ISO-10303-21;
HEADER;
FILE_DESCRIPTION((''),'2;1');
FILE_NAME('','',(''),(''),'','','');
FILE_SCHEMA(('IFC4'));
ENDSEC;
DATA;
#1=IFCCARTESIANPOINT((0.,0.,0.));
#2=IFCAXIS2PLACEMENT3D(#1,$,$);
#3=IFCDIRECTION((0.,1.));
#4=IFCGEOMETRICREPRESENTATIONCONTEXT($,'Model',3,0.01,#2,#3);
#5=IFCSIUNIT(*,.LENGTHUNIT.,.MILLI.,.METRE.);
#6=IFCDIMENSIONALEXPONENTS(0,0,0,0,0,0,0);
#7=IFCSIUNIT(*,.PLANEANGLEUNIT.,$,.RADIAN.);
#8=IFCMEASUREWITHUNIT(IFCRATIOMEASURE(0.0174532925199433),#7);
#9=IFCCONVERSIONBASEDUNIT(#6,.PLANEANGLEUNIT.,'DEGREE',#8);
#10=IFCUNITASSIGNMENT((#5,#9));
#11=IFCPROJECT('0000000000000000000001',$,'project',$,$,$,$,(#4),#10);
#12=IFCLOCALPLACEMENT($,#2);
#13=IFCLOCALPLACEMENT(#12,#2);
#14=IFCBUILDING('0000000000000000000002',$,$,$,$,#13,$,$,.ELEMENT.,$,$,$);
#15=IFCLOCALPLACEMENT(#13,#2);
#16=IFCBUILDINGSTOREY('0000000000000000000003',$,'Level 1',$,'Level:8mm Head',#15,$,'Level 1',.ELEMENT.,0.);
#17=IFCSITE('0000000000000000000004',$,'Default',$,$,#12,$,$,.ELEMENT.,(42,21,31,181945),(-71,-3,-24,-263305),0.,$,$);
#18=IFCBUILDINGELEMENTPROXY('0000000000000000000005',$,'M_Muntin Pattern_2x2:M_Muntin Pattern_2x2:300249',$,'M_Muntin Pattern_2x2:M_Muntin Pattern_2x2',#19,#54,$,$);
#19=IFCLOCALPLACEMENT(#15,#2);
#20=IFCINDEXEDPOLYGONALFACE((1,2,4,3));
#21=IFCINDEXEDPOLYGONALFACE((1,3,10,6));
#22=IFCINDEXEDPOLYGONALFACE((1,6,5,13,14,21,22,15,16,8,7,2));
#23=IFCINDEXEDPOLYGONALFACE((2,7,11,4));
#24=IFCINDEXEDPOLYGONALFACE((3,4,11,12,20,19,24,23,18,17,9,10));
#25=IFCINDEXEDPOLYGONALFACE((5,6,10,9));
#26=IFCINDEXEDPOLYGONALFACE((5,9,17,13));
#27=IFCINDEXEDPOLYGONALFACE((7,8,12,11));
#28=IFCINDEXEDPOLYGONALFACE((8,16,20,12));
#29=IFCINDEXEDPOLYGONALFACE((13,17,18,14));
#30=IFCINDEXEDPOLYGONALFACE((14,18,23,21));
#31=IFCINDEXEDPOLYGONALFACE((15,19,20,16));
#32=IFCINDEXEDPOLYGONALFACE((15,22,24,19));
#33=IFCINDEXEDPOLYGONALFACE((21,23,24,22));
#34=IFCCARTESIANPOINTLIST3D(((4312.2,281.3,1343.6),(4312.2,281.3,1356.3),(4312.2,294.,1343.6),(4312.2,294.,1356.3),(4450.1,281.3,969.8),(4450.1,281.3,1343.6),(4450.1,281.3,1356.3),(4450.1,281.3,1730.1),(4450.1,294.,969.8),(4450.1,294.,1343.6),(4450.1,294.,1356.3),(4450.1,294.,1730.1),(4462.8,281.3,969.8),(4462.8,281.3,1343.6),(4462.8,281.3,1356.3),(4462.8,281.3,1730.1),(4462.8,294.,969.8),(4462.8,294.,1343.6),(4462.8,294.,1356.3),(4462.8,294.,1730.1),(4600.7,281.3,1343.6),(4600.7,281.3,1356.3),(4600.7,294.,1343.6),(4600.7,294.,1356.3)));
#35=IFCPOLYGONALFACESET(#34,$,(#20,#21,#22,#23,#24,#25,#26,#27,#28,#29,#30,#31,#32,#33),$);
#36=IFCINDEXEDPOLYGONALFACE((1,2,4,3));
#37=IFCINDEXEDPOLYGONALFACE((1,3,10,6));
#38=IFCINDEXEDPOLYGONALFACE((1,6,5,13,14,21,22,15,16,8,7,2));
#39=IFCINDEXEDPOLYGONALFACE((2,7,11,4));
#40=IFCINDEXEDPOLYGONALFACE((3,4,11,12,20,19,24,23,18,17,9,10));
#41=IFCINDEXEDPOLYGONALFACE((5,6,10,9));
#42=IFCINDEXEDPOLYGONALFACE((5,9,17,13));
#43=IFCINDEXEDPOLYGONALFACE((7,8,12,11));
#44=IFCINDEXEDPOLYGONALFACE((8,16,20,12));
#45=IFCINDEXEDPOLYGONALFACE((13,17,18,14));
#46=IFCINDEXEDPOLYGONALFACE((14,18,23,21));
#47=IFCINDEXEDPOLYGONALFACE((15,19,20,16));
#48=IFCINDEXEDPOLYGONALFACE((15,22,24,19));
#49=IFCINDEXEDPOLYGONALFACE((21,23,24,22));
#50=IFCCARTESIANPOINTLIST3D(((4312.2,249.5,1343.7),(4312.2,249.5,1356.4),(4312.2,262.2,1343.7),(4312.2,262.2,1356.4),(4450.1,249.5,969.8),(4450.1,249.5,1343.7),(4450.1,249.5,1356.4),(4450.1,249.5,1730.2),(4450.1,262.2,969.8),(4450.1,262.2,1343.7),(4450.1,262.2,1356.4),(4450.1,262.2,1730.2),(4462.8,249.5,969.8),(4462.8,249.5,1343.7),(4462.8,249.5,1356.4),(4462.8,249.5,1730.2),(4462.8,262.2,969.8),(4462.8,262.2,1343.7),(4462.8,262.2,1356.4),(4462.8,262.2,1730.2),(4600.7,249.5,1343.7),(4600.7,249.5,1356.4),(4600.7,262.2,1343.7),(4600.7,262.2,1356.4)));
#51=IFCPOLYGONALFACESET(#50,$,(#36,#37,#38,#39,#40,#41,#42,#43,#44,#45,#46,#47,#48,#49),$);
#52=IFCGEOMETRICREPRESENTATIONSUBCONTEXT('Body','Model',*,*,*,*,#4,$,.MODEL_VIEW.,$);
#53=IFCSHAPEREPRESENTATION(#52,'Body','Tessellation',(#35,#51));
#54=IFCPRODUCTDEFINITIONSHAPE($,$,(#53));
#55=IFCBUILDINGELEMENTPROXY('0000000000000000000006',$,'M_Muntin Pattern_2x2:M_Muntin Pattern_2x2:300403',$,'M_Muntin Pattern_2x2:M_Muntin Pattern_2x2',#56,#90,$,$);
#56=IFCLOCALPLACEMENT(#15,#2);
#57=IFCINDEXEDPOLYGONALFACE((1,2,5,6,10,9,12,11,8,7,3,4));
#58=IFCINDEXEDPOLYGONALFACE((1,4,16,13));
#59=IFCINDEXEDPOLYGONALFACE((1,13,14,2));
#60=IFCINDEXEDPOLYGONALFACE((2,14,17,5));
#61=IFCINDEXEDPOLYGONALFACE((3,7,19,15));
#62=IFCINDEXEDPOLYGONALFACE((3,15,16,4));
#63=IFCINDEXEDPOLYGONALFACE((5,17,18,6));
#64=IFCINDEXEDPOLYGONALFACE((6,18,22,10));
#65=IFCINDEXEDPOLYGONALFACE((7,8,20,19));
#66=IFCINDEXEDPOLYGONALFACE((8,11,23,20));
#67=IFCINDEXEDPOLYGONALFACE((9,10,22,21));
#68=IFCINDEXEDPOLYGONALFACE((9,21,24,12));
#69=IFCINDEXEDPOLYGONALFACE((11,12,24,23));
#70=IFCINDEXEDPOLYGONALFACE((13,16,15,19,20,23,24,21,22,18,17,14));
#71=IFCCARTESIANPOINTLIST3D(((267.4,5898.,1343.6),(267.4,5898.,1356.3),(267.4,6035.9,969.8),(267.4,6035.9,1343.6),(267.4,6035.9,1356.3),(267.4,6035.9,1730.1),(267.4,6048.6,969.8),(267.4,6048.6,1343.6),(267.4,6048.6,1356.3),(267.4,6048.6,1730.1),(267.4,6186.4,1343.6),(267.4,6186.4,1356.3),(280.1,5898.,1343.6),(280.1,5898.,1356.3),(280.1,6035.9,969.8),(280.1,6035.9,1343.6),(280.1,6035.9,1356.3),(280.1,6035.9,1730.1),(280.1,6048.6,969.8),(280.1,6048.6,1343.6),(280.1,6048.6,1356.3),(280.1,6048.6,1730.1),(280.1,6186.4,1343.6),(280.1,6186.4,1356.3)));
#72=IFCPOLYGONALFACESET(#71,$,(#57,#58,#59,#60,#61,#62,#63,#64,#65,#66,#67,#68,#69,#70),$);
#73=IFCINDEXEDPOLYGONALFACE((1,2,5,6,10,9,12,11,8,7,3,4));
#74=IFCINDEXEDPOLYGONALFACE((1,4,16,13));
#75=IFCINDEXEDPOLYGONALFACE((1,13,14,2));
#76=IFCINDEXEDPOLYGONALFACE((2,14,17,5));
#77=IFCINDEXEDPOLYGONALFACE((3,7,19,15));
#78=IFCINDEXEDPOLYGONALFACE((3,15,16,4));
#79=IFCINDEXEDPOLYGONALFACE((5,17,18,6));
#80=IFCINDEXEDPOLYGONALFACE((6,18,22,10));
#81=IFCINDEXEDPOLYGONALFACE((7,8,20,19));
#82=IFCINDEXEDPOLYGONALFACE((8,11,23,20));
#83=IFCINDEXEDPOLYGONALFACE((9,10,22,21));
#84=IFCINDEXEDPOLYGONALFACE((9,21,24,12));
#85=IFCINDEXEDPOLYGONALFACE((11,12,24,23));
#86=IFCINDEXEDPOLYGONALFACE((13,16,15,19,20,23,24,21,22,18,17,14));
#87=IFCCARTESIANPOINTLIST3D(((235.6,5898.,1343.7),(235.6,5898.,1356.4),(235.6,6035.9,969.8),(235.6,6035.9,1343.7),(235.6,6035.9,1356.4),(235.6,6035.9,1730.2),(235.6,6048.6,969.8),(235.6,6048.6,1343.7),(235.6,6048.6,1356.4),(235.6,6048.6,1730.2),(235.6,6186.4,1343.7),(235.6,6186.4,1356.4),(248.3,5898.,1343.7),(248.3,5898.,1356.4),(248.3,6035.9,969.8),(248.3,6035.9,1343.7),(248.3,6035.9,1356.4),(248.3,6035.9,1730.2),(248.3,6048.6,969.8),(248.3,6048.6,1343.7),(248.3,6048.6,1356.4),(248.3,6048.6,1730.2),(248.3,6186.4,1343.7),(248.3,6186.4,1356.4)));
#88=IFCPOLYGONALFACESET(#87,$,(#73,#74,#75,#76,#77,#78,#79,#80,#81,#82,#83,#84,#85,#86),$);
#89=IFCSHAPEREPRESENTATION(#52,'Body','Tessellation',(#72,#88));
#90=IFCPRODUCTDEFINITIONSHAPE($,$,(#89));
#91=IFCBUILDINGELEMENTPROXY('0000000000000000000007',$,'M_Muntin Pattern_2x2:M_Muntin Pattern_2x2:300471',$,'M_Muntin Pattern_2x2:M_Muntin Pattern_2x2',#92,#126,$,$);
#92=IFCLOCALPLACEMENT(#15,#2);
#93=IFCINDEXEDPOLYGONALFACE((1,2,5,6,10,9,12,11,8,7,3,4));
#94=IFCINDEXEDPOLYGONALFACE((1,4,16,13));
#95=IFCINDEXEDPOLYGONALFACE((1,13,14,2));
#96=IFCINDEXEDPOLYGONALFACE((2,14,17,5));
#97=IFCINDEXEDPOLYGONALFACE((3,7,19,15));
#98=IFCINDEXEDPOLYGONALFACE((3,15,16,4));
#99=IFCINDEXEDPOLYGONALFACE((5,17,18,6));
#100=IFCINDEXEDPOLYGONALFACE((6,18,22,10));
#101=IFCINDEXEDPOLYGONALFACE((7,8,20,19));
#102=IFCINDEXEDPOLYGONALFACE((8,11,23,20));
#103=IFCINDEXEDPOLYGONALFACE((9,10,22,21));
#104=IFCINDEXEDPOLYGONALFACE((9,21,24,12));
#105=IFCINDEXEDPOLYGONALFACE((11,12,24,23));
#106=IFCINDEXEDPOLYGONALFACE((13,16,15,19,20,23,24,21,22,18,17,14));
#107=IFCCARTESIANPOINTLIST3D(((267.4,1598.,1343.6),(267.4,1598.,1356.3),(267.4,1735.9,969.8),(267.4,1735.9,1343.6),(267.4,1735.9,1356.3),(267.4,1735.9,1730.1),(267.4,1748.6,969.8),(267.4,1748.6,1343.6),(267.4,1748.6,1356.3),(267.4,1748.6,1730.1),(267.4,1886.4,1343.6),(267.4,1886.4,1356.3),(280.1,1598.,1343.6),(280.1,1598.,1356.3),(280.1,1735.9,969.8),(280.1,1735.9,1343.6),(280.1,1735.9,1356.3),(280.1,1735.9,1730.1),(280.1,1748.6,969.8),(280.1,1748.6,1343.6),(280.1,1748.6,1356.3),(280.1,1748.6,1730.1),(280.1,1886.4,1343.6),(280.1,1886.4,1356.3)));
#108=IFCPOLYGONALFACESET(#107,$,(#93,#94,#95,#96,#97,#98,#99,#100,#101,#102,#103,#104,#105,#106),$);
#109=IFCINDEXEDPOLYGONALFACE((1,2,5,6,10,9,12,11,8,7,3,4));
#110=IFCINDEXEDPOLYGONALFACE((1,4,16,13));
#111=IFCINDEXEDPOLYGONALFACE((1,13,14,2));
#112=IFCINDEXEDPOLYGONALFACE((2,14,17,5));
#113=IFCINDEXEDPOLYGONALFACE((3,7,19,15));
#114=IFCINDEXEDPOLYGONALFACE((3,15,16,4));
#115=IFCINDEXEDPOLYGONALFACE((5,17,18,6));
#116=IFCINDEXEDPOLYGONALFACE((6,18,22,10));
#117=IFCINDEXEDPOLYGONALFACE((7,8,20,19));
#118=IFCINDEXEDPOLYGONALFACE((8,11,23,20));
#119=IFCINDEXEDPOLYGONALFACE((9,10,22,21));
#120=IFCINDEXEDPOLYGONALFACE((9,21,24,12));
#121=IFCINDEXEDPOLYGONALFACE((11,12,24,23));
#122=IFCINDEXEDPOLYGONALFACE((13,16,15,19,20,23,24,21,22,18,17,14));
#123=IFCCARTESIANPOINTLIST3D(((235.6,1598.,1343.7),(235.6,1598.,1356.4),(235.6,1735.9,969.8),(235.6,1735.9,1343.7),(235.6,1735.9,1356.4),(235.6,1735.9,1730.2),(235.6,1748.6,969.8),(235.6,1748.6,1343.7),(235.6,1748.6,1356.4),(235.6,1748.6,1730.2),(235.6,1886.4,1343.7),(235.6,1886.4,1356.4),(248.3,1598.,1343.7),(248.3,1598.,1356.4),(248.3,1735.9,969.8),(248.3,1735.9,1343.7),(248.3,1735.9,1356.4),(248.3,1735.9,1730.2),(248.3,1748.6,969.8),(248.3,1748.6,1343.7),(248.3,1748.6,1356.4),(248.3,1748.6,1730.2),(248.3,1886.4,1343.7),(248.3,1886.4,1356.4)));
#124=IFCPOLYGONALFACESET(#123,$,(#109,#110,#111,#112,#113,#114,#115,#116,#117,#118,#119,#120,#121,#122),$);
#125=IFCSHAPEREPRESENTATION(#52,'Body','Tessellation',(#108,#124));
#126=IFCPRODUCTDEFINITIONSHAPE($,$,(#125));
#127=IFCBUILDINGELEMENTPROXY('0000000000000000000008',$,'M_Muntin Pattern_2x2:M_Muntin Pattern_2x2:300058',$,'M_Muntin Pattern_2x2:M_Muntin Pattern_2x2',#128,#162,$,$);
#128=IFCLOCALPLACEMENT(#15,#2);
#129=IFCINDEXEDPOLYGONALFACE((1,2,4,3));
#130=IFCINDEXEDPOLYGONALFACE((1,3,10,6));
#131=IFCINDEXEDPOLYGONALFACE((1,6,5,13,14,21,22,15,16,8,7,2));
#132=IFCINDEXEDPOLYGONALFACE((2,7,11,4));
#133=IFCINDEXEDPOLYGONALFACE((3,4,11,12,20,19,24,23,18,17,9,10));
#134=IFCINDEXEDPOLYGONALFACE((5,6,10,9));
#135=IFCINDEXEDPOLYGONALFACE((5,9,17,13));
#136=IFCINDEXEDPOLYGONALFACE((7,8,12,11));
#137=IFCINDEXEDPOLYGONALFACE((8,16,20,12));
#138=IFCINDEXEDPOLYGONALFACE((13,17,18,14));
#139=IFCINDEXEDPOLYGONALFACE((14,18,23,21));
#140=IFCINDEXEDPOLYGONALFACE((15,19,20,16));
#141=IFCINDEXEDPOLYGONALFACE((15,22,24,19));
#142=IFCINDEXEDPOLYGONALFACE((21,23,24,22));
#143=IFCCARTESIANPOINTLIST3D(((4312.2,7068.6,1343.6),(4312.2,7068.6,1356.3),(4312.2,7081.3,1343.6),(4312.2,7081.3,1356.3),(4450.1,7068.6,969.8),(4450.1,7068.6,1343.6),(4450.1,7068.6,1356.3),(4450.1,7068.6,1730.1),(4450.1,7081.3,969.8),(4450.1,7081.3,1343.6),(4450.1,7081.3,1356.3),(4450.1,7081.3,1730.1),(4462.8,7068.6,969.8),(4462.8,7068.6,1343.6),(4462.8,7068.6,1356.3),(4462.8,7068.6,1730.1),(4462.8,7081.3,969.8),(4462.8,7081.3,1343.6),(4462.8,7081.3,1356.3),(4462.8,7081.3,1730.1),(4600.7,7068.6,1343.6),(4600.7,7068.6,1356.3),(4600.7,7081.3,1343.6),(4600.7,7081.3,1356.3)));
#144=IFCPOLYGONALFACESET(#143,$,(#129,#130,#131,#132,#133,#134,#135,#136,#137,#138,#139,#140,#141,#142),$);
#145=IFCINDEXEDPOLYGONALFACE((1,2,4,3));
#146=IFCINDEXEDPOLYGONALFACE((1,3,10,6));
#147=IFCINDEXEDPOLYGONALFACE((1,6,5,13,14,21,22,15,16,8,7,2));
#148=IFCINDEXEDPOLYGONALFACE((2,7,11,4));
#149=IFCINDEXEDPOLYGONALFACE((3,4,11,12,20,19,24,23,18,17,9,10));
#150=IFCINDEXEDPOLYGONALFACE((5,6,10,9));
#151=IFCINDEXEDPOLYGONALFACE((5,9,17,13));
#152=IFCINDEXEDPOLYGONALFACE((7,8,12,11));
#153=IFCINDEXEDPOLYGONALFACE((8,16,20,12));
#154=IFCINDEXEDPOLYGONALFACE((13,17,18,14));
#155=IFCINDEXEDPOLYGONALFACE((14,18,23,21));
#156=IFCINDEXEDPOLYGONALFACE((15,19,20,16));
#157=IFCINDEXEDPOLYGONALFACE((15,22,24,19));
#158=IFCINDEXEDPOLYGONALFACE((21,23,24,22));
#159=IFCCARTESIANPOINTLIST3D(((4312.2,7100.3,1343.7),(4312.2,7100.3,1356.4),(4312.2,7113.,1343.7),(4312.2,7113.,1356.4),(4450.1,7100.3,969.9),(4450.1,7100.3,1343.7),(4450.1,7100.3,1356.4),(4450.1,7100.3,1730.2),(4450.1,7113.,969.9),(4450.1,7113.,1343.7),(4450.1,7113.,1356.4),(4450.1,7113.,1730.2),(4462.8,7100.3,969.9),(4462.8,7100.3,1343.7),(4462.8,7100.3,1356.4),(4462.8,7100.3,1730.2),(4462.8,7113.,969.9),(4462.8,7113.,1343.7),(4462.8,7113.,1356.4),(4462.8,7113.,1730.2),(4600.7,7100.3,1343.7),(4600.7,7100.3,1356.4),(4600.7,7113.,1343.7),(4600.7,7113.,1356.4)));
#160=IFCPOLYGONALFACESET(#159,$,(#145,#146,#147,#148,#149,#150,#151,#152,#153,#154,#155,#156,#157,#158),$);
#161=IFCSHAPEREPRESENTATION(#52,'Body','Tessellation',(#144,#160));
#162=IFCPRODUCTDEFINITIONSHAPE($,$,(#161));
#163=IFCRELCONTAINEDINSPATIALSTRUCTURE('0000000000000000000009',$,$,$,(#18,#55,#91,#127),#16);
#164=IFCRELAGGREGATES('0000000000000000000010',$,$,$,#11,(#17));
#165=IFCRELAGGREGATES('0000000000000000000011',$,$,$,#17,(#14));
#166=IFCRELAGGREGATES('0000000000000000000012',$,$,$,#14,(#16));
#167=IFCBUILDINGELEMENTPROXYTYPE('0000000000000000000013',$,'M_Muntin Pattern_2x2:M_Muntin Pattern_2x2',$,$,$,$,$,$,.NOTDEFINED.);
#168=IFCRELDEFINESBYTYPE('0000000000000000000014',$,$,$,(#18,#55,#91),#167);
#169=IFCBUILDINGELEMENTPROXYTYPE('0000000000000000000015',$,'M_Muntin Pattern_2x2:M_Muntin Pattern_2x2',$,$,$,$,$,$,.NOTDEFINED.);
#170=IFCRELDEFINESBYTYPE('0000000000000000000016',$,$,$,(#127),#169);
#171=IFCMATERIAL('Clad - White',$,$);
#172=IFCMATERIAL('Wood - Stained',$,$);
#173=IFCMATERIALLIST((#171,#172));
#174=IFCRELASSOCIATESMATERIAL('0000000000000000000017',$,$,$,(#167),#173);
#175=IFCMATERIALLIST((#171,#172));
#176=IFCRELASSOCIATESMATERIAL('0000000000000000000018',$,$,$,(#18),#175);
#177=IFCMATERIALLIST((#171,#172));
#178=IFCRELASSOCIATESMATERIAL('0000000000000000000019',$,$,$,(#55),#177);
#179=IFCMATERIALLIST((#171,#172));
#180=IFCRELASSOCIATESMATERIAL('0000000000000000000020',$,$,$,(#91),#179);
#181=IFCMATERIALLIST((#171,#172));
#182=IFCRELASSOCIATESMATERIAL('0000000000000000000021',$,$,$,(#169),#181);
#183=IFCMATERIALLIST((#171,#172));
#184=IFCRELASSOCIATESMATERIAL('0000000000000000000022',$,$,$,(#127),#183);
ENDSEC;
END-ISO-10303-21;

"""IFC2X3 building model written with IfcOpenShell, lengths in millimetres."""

from ifc_helpers import new_model, entity, si_unit, converted_unit, direction, frame, origin, place, context, subcontext, project, spatial, polyline, outline, extrude, source, transform, mapped, material, material_list, type_object, type_shapes, element, save


model = new_model("IFC2X3")

# Units and contexts
model_context = context("Model", 3, precision=0.01, world=origin(), true_north=direction((0.0, 1.0)))
body_context = subcontext(model_context, "Body", "Model", "MODEL_VIEW")
ifc_project = project(units=[si_unit("LENGTHUNIT", "METRE", prefix="MILLI"), converted_unit("PLANEANGLEUNIT", "DEGREE", entity("IfcRatioMeasure", 0.0174532925199433), si_unit("PLANEANGLEUNIT", "RADIAN"), dimensions=[0, 0, 0, 0, 0, 0, 0])], contexts=[model_context])

# Site, building, storey
site_placement = place(None, origin())
site = spatial("IfcSite", under=ifc_project, at=site_placement, Name="Default", CompositionType="ELEMENT", RefLatitude=(42, 21, 31, 181945), RefLongitude=(-71, -3, -24, -263305), RefElevation=0.0)
building_placement = place(site_placement, origin())
building = spatial("IfcBuilding", under=site, at=building_placement, CompositionType="ELEMENT")
storey_placement = place(building_placement, origin())
storey = spatial("IfcBuildingStorey", under=building, at=storey_placement, Name="Level 1", ObjectType="Level:8mm Head", LongName="Level 1", CompositionType="ELEMENT", Elevation=0.0)

# Building element proxies
ifc_material_1 = material(Name="Clad - White")
ifc_material_2 = material(Name="Wood - Stained")
ifc_material_list_1 = material_list([ifc_material_1, ifc_material_2])
ifc_material_list_2 = material_list([ifc_material_1, ifc_material_2])
building_element_proxy_type_1 = type_object("IfcBuildingElementProxyType", Name="M_Muntin Pattern_2x2:M_Muntin Pattern_2x2", PredefinedType="NOTDEFINED", material=ifc_material_list_2)
shared_shape_1 = source(origin(), body_context, "Body", "SweptSolid", [
    extrude(outline(polyline([(6.4, -6.4), (380.1, -6.4), (380.1, 6.3), (6.4, 6.3), (6.4, 144.2), (-6.3, 144.2), (-6.3, 6.3), (-380.2, 6.3), (-380.2, -6.4), (-6.3, -6.4), (-6.3, -144.2), (6.4, -144.2), (6.4, -6.4)])), frame((0.0, 9.5, 380.1), z_axis=(0.0, 1.0, 0.0), x_axis=(0.0, 0.0, 1.0)), (0.0, 0.0, 1.0), 12.7),
    extrude(outline(polyline([(6.4, -6.4), (380.2, -6.4), (380.2, 6.3), (6.4, 6.3), (6.4, 144.2), (-6.3, 144.2), (-6.3, 6.3), (-380.2, 6.3), (-380.2, -6.4), (-6.3, -6.4), (-6.3, -144.2), (6.4, -144.2), (6.4, -6.4)])), frame((0.0, -22.2, 380.2), z_axis=(0.0, 1.0, 0.0), x_axis=(0.0, 0.0, 1.0)), (0.0, 0.0, 1.0), 12.7),
])
type_shapes(building_element_proxy_type_1, [shared_shape_1])
proxy_1_placement = place(storey_placement, frame((4456.5, 271.8, 969.8)))
element("IfcBuildingElementProxy", 1, at=proxy_1_placement, inside=storey, type_object=building_element_proxy_type_1, material=ifc_material_list_1, Name="M_Muntin Pattern_2x2:M_Muntin Pattern_2x2:300249", ObjectType="M_Muntin Pattern_2x2:M_Muntin Pattern_2x2", context=body_context, shape_type="MappedRepresentation", body=[
    mapped(shared_shape_1, transform((0.0, 0.0, 0.0), scale=1.0)),
])
ifc_material_list_3 = material_list([ifc_material_1, ifc_material_2])
proxy_2_placement = place(storey_placement, frame((257.9, 6042.2, 969.8), z_axis=(0.0, 0.0, 1.0), x_axis=(0.0, -1.0, 0.0)))
element("IfcBuildingElementProxy", 2, at=proxy_2_placement, inside=storey, type_object=building_element_proxy_type_1, material=ifc_material_list_3, Name="M_Muntin Pattern_2x2:M_Muntin Pattern_2x2:300403", ObjectType="M_Muntin Pattern_2x2:M_Muntin Pattern_2x2", context=body_context, shape_type="MappedRepresentation", body=[
    mapped(shared_shape_1, transform((0.0, 0.0, 0.0), scale=1.0)),
])
ifc_material_list_4 = material_list([ifc_material_1, ifc_material_2])
proxy_3_placement = place(storey_placement, frame((257.9, 1742.2, 969.8), z_axis=(0.0, 0.0, 1.0), x_axis=(0.0, -1.0, 0.0)))
element("IfcBuildingElementProxy", 3, at=proxy_3_placement, inside=storey, type_object=building_element_proxy_type_1, material=ifc_material_list_4, Name="M_Muntin Pattern_2x2:M_Muntin Pattern_2x2:300471", ObjectType="M_Muntin Pattern_2x2:M_Muntin Pattern_2x2", context=body_context, shape_type="MappedRepresentation", body=[
    mapped(shared_shape_1, transform((0.0, 0.0, 0.0), scale=1.0)),
])
ifc_material_list_5 = material_list([ifc_material_1, ifc_material_2])
ifc_material_list_6 = material_list([ifc_material_1, ifc_material_2])
building_element_proxy_type_2 = type_object("IfcBuildingElementProxyType", Name="M_Muntin Pattern_2x2:M_Muntin Pattern_2x2", PredefinedType="NOTDEFINED", material=ifc_material_list_6)
shared_shape_2 = source(origin(), body_context, "Body", "SweptSolid", [
    extrude(outline(polyline([(6.4, -6.4), (380.1, -6.4), (380.1, 6.3), (6.4, 6.3), (6.4, 144.2), (-6.3, 144.2), (-6.3, 6.3), (-380.2, 6.3), (-380.2, -6.4), (-6.3, -6.4), (-6.3, -144.2), (6.4, -144.2), (6.4, -6.4)])), frame((0.0, -22.2, 380.1), z_axis=(0.0, 1.0, 0.0), x_axis=(0.0, 0.0, 1.0)), (0.0, 0.0, 1.0), 12.7),
    extrude(outline(polyline([(6.4, -6.4), (380.2, -6.4), (380.2, 6.3), (6.4, 6.3), (6.4, 144.2), (-6.3, 144.2), (-6.3, 6.3), (-380.2, 6.3), (-380.2, -6.4), (-6.3, -6.4), (-6.3, -144.2), (6.4, -144.2), (6.4, -6.4)])), frame((0.0, 9.5, 380.2), z_axis=(0.0, 1.0, 0.0), x_axis=(0.0, 0.0, 1.0)), (0.0, 0.0, 1.0), 12.7),
])
type_shapes(building_element_proxy_type_2, [shared_shape_2])
proxy_4_placement = place(storey_placement, frame((4456.5, 7090.8, 969.9)))
element("IfcBuildingElementProxy", 4, at=proxy_4_placement, inside=storey, type_object=building_element_proxy_type_2, material=ifc_material_list_5, Name="M_Muntin Pattern_2x2:M_Muntin Pattern_2x2:300058", ObjectType="M_Muntin Pattern_2x2:M_Muntin Pattern_2x2", context=body_context, shape_type="MappedRepresentation", body=[
    mapped(shared_shape_2, transform((0.0, 0.0, 0.0), scale=1.0)),
])

save(model, "model.ifc")
